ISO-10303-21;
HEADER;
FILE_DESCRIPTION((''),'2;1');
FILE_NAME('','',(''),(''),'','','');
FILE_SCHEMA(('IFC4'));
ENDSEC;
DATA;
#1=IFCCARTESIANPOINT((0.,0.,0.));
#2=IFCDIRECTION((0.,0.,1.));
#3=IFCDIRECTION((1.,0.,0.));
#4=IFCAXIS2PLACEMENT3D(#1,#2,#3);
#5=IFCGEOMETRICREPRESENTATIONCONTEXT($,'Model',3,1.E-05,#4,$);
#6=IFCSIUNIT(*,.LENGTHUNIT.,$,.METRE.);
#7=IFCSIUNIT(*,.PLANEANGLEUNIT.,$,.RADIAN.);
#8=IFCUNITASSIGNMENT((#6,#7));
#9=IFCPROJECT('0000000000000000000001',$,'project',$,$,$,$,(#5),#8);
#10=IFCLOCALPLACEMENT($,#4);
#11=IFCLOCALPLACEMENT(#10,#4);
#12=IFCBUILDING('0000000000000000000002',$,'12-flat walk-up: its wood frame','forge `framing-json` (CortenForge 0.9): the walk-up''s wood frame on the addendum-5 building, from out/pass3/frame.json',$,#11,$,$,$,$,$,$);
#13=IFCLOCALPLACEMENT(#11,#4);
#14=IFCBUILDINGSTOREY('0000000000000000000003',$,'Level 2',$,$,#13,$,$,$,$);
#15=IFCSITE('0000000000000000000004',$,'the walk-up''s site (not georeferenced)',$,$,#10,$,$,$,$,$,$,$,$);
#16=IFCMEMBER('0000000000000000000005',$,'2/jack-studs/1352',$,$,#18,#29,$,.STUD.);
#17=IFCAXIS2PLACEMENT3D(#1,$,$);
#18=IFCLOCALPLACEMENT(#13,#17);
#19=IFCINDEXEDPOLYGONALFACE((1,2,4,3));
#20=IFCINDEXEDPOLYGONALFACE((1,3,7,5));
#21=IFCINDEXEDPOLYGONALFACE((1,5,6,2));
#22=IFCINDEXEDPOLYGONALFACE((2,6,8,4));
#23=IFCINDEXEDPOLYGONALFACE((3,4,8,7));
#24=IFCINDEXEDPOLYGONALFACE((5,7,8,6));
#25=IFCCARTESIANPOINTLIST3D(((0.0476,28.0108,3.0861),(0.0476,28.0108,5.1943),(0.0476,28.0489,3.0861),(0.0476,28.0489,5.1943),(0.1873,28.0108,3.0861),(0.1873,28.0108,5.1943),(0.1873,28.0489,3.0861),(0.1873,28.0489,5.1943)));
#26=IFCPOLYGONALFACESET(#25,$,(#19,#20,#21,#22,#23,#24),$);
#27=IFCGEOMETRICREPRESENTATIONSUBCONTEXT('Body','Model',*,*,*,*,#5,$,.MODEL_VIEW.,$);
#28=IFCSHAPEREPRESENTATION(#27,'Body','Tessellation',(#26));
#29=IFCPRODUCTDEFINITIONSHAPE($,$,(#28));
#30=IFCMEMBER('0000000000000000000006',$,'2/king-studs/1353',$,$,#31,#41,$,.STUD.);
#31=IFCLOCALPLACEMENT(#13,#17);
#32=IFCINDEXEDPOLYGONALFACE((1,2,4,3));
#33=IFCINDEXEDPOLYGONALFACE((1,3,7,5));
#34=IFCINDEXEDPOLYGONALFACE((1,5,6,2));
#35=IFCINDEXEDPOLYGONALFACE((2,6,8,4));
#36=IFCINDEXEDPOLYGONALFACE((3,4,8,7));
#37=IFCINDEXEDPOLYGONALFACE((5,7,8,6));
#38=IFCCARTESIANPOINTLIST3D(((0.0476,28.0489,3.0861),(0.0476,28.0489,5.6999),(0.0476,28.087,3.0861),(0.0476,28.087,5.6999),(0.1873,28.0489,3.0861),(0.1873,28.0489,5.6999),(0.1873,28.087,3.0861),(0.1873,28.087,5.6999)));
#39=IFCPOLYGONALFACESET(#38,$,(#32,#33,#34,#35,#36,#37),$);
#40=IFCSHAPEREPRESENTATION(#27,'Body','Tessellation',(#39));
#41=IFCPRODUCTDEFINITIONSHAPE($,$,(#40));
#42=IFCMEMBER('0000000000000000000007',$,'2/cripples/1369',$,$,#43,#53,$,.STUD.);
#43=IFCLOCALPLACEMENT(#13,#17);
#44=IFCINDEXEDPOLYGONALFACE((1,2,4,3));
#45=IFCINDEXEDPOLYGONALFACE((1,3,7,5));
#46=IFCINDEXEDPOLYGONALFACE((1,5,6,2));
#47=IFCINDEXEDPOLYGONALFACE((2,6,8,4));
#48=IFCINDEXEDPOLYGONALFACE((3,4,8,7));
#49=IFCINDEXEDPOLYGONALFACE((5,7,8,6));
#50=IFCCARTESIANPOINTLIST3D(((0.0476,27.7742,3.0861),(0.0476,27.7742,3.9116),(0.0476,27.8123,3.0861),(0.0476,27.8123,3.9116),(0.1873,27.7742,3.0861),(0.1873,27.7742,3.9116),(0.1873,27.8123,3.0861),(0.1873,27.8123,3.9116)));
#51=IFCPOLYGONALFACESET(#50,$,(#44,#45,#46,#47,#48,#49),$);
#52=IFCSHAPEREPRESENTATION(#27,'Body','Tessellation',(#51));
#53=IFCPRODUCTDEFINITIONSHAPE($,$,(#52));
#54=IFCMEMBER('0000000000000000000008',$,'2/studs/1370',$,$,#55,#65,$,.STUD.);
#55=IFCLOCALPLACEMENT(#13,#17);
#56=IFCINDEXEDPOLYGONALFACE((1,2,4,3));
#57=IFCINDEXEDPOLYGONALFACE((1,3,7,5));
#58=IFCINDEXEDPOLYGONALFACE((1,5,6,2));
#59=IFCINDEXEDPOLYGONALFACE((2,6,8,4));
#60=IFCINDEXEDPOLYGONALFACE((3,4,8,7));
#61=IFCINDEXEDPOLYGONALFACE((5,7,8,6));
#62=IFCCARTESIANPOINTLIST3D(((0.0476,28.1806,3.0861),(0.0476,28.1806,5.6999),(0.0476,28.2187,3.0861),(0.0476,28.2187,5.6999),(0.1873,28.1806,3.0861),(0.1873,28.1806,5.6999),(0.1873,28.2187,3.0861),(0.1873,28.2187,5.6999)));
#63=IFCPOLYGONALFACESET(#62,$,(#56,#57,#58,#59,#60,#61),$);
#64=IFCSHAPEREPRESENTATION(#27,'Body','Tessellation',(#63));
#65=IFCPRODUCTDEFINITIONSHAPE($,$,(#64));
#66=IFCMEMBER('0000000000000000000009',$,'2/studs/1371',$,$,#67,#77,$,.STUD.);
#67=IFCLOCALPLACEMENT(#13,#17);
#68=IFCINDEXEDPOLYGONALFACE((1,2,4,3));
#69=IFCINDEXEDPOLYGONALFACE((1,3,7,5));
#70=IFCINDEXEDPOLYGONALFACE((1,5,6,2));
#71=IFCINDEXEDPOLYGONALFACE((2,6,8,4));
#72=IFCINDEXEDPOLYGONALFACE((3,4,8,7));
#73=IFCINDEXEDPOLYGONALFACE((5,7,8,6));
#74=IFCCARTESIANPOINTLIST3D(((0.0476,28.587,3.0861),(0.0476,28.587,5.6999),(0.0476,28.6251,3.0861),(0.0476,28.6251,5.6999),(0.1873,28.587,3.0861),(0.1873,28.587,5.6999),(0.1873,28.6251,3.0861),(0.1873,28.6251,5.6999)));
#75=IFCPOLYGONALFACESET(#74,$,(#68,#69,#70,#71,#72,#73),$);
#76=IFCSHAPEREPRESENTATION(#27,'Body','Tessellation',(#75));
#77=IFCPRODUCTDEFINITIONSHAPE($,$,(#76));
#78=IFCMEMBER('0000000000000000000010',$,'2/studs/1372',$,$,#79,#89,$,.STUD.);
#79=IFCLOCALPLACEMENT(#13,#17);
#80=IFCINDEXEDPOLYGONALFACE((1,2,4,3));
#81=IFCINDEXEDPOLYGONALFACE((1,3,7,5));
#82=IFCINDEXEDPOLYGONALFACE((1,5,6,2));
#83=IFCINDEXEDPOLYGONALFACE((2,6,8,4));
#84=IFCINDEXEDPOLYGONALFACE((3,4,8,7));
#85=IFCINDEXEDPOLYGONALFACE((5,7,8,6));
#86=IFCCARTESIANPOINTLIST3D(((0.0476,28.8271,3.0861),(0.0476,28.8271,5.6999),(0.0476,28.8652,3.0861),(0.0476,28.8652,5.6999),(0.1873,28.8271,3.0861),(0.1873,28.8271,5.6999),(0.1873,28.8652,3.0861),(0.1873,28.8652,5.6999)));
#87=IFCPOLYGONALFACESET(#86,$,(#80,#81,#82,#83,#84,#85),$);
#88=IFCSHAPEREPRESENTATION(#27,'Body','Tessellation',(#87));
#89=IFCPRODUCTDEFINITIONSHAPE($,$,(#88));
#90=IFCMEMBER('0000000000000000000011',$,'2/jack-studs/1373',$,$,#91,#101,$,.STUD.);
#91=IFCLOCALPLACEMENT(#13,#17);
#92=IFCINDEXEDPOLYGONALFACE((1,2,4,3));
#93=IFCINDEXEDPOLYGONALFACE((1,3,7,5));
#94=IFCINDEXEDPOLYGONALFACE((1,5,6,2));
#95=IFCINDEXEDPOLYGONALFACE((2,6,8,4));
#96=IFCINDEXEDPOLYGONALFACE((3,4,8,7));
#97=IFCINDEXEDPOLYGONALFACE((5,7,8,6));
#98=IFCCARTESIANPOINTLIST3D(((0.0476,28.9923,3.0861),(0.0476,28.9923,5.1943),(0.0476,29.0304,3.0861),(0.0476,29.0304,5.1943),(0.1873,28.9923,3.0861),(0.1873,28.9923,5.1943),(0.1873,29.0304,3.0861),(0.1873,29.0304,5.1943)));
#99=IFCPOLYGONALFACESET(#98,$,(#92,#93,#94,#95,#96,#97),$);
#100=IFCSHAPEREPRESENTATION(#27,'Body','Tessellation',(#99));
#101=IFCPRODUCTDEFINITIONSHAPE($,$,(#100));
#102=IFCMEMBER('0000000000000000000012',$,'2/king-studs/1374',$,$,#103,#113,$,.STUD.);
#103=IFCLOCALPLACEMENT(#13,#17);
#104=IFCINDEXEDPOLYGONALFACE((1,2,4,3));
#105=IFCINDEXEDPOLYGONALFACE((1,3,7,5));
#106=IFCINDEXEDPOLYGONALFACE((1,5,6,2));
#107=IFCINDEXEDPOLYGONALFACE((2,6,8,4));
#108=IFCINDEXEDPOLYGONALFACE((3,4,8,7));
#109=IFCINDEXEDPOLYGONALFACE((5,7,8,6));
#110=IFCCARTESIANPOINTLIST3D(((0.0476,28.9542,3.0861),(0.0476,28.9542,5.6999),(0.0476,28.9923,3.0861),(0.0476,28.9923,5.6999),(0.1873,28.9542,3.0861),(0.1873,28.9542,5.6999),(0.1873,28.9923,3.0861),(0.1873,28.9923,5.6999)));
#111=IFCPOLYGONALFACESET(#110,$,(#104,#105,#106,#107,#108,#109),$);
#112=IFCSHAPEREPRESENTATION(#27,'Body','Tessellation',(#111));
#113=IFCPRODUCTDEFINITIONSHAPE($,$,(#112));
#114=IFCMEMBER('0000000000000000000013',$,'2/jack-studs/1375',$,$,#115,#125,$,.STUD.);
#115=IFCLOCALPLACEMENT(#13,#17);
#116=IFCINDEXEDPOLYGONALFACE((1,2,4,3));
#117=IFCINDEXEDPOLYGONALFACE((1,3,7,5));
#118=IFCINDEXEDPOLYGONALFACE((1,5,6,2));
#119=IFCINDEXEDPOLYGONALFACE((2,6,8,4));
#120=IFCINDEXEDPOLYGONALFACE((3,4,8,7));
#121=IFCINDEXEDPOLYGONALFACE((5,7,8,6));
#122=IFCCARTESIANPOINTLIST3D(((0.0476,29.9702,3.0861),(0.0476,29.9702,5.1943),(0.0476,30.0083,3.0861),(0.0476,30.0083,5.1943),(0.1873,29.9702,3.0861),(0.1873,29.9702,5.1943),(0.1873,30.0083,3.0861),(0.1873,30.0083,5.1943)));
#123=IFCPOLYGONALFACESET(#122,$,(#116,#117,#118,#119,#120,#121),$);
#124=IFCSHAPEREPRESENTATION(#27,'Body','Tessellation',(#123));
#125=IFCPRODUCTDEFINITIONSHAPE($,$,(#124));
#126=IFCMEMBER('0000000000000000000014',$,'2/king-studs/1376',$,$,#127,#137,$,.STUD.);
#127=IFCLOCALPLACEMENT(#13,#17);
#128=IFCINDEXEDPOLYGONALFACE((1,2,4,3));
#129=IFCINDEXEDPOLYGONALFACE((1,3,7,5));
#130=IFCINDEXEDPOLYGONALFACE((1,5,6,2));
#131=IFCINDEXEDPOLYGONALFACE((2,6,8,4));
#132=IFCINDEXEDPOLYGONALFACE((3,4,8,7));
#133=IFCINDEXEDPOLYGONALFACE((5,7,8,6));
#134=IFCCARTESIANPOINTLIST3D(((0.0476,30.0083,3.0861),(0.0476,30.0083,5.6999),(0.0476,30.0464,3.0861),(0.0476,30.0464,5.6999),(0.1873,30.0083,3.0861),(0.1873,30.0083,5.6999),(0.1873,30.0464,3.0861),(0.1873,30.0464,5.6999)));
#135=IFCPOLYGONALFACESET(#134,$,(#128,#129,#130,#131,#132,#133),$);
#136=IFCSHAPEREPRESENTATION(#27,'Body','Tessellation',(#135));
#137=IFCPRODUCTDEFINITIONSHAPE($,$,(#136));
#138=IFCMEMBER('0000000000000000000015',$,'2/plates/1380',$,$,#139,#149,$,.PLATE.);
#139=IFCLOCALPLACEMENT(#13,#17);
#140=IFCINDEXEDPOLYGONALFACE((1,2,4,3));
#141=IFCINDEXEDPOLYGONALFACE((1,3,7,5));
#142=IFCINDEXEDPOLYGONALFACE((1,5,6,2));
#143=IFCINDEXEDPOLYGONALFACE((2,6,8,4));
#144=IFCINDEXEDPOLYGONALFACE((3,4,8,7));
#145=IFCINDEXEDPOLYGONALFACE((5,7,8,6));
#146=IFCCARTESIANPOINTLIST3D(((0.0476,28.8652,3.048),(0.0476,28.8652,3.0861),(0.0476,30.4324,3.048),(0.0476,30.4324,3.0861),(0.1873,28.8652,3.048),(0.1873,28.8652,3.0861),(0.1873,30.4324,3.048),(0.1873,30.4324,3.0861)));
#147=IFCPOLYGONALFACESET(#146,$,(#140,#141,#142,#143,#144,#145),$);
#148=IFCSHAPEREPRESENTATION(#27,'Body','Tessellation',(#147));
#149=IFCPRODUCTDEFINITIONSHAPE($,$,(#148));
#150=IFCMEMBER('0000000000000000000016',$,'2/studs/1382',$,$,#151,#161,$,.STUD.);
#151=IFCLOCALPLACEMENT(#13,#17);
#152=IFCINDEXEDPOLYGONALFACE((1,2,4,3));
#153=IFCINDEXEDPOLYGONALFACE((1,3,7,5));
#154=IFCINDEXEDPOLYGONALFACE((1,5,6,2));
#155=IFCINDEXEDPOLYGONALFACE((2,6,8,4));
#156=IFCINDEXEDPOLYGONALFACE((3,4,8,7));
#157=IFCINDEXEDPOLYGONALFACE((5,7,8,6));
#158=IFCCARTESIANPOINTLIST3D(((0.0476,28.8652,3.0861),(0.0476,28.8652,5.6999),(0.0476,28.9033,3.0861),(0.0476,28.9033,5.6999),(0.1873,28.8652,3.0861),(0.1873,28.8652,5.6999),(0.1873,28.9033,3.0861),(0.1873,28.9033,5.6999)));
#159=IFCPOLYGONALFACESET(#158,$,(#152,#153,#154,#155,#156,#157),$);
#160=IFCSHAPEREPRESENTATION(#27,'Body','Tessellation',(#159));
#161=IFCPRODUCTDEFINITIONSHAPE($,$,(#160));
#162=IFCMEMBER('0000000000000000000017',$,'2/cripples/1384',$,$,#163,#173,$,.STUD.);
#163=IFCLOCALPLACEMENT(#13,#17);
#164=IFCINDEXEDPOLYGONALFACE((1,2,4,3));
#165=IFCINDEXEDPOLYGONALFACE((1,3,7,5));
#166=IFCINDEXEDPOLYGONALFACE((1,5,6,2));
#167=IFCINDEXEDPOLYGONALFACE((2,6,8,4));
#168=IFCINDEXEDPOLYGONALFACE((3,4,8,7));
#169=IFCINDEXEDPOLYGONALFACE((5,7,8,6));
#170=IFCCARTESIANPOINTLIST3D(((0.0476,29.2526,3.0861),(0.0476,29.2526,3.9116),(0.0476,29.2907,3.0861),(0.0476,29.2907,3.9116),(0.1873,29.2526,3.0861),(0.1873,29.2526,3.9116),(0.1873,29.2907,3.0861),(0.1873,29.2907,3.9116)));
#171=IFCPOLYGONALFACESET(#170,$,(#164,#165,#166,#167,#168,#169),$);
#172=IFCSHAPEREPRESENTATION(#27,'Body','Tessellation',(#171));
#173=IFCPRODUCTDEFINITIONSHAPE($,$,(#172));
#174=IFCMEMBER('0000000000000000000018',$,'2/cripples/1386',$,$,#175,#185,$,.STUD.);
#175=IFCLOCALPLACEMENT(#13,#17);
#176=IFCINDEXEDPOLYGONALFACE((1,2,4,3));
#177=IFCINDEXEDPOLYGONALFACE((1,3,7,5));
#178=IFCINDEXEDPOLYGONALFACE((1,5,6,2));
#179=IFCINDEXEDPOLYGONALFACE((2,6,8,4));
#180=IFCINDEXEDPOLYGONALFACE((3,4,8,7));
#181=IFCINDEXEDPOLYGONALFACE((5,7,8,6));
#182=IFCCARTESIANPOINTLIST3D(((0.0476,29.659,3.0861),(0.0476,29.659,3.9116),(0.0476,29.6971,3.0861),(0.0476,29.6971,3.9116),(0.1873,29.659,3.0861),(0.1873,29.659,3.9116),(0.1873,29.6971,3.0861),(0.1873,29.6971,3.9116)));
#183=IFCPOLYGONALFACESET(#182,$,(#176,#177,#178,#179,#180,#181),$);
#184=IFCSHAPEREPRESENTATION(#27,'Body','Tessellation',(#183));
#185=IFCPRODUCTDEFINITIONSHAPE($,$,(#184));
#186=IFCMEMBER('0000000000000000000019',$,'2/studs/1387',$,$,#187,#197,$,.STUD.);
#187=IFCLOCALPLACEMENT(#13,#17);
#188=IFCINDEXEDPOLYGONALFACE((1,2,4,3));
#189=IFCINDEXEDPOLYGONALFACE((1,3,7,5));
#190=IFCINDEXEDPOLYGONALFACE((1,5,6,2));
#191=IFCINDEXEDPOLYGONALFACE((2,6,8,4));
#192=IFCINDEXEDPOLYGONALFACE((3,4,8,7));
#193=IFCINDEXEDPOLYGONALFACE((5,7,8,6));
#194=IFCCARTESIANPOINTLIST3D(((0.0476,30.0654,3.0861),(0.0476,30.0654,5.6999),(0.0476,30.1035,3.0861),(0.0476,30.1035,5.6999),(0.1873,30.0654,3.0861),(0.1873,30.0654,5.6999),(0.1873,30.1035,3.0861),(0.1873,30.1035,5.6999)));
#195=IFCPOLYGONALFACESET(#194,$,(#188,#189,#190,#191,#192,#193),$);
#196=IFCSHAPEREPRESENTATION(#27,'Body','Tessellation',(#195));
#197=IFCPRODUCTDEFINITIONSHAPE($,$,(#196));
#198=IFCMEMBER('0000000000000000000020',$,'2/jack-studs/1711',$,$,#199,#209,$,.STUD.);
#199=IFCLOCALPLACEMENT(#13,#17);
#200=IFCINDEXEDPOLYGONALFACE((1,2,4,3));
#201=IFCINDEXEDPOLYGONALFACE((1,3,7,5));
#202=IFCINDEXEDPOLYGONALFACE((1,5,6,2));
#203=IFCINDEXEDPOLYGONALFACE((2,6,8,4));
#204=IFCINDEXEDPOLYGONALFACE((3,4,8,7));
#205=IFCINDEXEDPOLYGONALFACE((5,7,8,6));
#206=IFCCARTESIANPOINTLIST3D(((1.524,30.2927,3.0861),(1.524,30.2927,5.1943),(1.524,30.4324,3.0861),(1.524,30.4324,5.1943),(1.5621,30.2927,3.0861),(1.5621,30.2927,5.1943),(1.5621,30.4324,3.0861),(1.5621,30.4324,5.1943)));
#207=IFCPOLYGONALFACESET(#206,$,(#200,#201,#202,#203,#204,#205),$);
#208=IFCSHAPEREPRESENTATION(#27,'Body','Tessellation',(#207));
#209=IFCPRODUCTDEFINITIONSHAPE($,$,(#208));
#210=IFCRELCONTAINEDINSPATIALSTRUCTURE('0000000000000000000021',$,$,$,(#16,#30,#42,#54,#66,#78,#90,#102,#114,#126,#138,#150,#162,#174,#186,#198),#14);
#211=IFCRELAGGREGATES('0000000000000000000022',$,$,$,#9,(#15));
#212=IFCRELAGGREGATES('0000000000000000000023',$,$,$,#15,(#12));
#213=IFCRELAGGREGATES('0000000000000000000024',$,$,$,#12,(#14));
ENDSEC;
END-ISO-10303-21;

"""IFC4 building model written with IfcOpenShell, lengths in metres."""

from ifc_helpers import new_model, si_unit, frame, frame_2d, origin, origin_with_axes, place, context, subcontext, project, spatial, rectangle, extrude, element, save


model = new_model("IFC4")

# Units and contexts
model_context = context("Model", 3, precision=1e-05, world=origin_with_axes())
body_context = subcontext(model_context, "Body", "Model", "MODEL_VIEW")
ifc_project = project(units=[si_unit("LENGTHUNIT", "METRE"), si_unit("PLANEANGLEUNIT", "RADIAN")], contexts=[model_context])

# Site, building, storey
site_placement = place(None, origin_with_axes())
site = spatial("IfcSite", under=ifc_project, at=site_placement, Name="the walk-up's site (not georeferenced)")
building_placement = place(site_placement, origin_with_axes())
building = spatial("IfcBuilding", under=site, at=building_placement, Name="12-flat walk-up: its wood frame", Description="forge `framing-json` (CortenForge 0.9): the walk-up's wood frame on the addendum-5 building, from out/pass3/frame.json")
storey_placement = place(building_placement, origin_with_axes())
storey = spatial("IfcBuildingStorey", under=building, at=storey_placement, Name="Level 2")

# Members
member_1_placement = place(storey_placement, frame((0.0476, 28.0108, 3.0861), z_axis=(0.0, 0.0, 1.0), x_axis=(1.0, 0.0, 0.0)))
element("IfcMember", 1, at=member_1_placement, inside=storey, Name="2/jack-studs/1352", PredefinedType="STUD", context=body_context, shape_type="SweptSolid", body=[
    extrude(rectangle(XDim=0.1397, YDim=0.0381, at=frame_2d((0.0698, 0.0191))), origin(), (0.0, 0.0, 1.0), 2.1082),
])
member_2_placement = place(storey_placement, frame((0.0476, 28.0489, 3.0861), z_axis=(0.0, 0.0, 1.0), x_axis=(1.0, 0.0, 0.0)))
element("IfcMember", 2, at=member_2_placement, inside=storey, Name="2/king-studs/1353", PredefinedType="STUD", context=body_context, shape_type="SweptSolid", body=[
    extrude(rectangle(XDim=0.1397, YDim=0.0381, at=frame_2d((0.0698, 0.0191))), origin(), (0.0, 0.0, 1.0), 2.6138),
])
member_3_placement = place(storey_placement, frame((0.0476, 27.7742, 3.0861), z_axis=(0.0, 0.0, 1.0), x_axis=(1.0, 0.0, 0.0)))
element("IfcMember", 3, at=member_3_placement, inside=storey, Name="2/cripples/1369", PredefinedType="STUD", context=body_context, shape_type="SweptSolid", body=[
    extrude(rectangle(XDim=0.1397, YDim=0.0381, at=frame_2d((0.0698, 0.0191))), origin(), (0.0, 0.0, 1.0), 0.8255),
])
for number, where, z_axis, x_axis, name in (
    (4, (0.0476, 28.1806, 3.0861), (0.0, 0.0, 1.0), (1.0, 0.0, 0.0), "2/studs/1370"),
    (5, (0.0476, 28.587, 3.0861), (0.0, 0.0, 1.0), (1.0, 0.0, 0.0), "2/studs/1371"),
    (6, (0.0476, 28.8271, 3.0861), (0.0, 0.0, 1.0), (1.0, 0.0, 0.0), "2/studs/1372"),
):
    element("IfcMember", number, at=place(storey_placement, frame(where, z_axis=z_axis, x_axis=x_axis)), inside=storey, Name=name, PredefinedType="STUD", context=body_context, shape_type="SweptSolid", body=[
        extrude(rectangle(XDim=0.1397, YDim=0.0381, at=frame_2d((0.0698, 0.0191))), origin(), (0.0, 0.0, 1.0), 2.6138),
    ])
member_4_placement = place(storey_placement, frame((0.0476, 28.9923, 3.0861), z_axis=(0.0, 0.0, 1.0), x_axis=(1.0, 0.0, 0.0)))
element("IfcMember", 7, at=member_4_placement, inside=storey, Name="2/jack-studs/1373", PredefinedType="STUD", context=body_context, shape_type="SweptSolid", body=[
    extrude(rectangle(XDim=0.1397, YDim=0.0381, at=frame_2d((0.0698, 0.0191))), origin(), (0.0, 0.0, 1.0), 2.1082),
])
member_5_placement = place(storey_placement, frame((0.0476, 28.9542, 3.0861), z_axis=(0.0, 0.0, 1.0), x_axis=(1.0, 0.0, 0.0)))
element("IfcMember", 8, at=member_5_placement, inside=storey, Name="2/king-studs/1374", PredefinedType="STUD", context=body_context, shape_type="SweptSolid", body=[
    extrude(rectangle(XDim=0.1397, YDim=0.0381, at=frame_2d((0.0698, 0.0191))), origin(), (0.0, 0.0, 1.0), 2.6138),
])
member_6_placement = place(storey_placement, frame((0.0476, 29.9702, 3.0861), z_axis=(0.0, 0.0, 1.0), x_axis=(1.0, 0.0, 0.0)))
element("IfcMember", 9, at=member_6_placement, inside=storey, Name="2/jack-studs/1375", PredefinedType="STUD", context=body_context, shape_type="SweptSolid", body=[
    extrude(rectangle(XDim=0.1397, YDim=0.0381, at=frame_2d((0.0698, 0.019))), origin(), (0.0, 0.0, 1.0), 2.1082),
])
member_7_placement = place(storey_placement, frame((0.0476, 30.0083, 3.0861), z_axis=(0.0, 0.0, 1.0), x_axis=(1.0, 0.0, 0.0)))
element("IfcMember", 10, at=member_7_placement, inside=storey, Name="2/king-studs/1376", PredefinedType="STUD", context=body_context, shape_type="SweptSolid", body=[
    extrude(rectangle(XDim=0.1397, YDim=0.0381, at=frame_2d((0.0698, 0.0191))), origin(), (0.0, 0.0, 1.0), 2.6138),
])
member_8_placement = place(storey_placement, frame((0.0476, 28.8652, 3.048), z_axis=(0.0, 0.0, 1.0), x_axis=(1.0, 0.0, 0.0)))
element("IfcMember", 11, at=member_8_placement, inside=storey, Name="2/plates/1380", PredefinedType="PLATE", context=body_context, shape_type="SweptSolid", body=[
    extrude(rectangle(XDim=0.1397, YDim=1.5672, at=frame_2d((0.0698, 0.7836))), origin(), (0.0, 0.0, 1.0), 0.0381),
])
member_9_placement = place(storey_placement, frame((0.0476, 28.8652, 3.0861), z_axis=(0.0, 0.0, 1.0), x_axis=(1.0, 0.0, 0.0)))
element("IfcMember", 12, at=member_9_placement, inside=storey, Name="2/studs/1382", PredefinedType="STUD", context=body_context, shape_type="SweptSolid", body=[
    extrude(rectangle(XDim=0.1397, YDim=0.0381, at=frame_2d((0.0698, 0.0191))), origin(), (0.0, 0.0, 1.0), 2.6138),
])
for number, where, z_axis, x_axis, name in (
    (13, (0.0476, 29.2526, 3.0861), (0.0, 0.0, 1.0), (1.0, 0.0, 0.0), "2/cripples/1384"),
    (14, (0.0476, 29.659, 3.0861), (0.0, 0.0, 1.0), (1.0, 0.0, 0.0), "2/cripples/1386"),
):
    element("IfcMember", number, at=place(storey_placement, frame(where, z_axis=z_axis, x_axis=x_axis)), inside=storey, Name=name, PredefinedType="STUD", context=body_context, shape_type="SweptSolid", body=[
        extrude(rectangle(XDim=0.1397, YDim=0.0381, at=frame_2d((0.0698, 0.0191))), origin(), (0.0, 0.0, 1.0), 0.8255),
    ])
member_10_placement = place(storey_placement, frame((0.0476, 30.0654, 3.0861), z_axis=(0.0, 0.0, 1.0), x_axis=(1.0, 0.0, 0.0)))
element("IfcMember", 15, at=member_10_placement, inside=storey, Name="2/studs/1387", PredefinedType="STUD", context=body_context, shape_type="SweptSolid", body=[
    extrude(rectangle(XDim=0.1397, YDim=0.0381, at=frame_2d((0.0698, 0.0191))), origin(), (0.0, 0.0, 1.0), 2.6138),
])
member_11_placement = place(storey_placement, frame((1.524, 30.2927, 3.0861), z_axis=(0.0, 0.0, 1.0), x_axis=(1.0, 0.0, 0.0)))
element("IfcMember", 16, at=member_11_placement, inside=storey, Name="2/jack-studs/1711", PredefinedType="STUD", context=body_context, shape_type="SweptSolid", body=[
    extrude(rectangle(XDim=0.0381, YDim=0.1397, at=frame_2d((0.0191, 0.0699))), origin(), (0.0, 0.0, 1.0), 2.1082),
])

save(model, "model.ifc")
